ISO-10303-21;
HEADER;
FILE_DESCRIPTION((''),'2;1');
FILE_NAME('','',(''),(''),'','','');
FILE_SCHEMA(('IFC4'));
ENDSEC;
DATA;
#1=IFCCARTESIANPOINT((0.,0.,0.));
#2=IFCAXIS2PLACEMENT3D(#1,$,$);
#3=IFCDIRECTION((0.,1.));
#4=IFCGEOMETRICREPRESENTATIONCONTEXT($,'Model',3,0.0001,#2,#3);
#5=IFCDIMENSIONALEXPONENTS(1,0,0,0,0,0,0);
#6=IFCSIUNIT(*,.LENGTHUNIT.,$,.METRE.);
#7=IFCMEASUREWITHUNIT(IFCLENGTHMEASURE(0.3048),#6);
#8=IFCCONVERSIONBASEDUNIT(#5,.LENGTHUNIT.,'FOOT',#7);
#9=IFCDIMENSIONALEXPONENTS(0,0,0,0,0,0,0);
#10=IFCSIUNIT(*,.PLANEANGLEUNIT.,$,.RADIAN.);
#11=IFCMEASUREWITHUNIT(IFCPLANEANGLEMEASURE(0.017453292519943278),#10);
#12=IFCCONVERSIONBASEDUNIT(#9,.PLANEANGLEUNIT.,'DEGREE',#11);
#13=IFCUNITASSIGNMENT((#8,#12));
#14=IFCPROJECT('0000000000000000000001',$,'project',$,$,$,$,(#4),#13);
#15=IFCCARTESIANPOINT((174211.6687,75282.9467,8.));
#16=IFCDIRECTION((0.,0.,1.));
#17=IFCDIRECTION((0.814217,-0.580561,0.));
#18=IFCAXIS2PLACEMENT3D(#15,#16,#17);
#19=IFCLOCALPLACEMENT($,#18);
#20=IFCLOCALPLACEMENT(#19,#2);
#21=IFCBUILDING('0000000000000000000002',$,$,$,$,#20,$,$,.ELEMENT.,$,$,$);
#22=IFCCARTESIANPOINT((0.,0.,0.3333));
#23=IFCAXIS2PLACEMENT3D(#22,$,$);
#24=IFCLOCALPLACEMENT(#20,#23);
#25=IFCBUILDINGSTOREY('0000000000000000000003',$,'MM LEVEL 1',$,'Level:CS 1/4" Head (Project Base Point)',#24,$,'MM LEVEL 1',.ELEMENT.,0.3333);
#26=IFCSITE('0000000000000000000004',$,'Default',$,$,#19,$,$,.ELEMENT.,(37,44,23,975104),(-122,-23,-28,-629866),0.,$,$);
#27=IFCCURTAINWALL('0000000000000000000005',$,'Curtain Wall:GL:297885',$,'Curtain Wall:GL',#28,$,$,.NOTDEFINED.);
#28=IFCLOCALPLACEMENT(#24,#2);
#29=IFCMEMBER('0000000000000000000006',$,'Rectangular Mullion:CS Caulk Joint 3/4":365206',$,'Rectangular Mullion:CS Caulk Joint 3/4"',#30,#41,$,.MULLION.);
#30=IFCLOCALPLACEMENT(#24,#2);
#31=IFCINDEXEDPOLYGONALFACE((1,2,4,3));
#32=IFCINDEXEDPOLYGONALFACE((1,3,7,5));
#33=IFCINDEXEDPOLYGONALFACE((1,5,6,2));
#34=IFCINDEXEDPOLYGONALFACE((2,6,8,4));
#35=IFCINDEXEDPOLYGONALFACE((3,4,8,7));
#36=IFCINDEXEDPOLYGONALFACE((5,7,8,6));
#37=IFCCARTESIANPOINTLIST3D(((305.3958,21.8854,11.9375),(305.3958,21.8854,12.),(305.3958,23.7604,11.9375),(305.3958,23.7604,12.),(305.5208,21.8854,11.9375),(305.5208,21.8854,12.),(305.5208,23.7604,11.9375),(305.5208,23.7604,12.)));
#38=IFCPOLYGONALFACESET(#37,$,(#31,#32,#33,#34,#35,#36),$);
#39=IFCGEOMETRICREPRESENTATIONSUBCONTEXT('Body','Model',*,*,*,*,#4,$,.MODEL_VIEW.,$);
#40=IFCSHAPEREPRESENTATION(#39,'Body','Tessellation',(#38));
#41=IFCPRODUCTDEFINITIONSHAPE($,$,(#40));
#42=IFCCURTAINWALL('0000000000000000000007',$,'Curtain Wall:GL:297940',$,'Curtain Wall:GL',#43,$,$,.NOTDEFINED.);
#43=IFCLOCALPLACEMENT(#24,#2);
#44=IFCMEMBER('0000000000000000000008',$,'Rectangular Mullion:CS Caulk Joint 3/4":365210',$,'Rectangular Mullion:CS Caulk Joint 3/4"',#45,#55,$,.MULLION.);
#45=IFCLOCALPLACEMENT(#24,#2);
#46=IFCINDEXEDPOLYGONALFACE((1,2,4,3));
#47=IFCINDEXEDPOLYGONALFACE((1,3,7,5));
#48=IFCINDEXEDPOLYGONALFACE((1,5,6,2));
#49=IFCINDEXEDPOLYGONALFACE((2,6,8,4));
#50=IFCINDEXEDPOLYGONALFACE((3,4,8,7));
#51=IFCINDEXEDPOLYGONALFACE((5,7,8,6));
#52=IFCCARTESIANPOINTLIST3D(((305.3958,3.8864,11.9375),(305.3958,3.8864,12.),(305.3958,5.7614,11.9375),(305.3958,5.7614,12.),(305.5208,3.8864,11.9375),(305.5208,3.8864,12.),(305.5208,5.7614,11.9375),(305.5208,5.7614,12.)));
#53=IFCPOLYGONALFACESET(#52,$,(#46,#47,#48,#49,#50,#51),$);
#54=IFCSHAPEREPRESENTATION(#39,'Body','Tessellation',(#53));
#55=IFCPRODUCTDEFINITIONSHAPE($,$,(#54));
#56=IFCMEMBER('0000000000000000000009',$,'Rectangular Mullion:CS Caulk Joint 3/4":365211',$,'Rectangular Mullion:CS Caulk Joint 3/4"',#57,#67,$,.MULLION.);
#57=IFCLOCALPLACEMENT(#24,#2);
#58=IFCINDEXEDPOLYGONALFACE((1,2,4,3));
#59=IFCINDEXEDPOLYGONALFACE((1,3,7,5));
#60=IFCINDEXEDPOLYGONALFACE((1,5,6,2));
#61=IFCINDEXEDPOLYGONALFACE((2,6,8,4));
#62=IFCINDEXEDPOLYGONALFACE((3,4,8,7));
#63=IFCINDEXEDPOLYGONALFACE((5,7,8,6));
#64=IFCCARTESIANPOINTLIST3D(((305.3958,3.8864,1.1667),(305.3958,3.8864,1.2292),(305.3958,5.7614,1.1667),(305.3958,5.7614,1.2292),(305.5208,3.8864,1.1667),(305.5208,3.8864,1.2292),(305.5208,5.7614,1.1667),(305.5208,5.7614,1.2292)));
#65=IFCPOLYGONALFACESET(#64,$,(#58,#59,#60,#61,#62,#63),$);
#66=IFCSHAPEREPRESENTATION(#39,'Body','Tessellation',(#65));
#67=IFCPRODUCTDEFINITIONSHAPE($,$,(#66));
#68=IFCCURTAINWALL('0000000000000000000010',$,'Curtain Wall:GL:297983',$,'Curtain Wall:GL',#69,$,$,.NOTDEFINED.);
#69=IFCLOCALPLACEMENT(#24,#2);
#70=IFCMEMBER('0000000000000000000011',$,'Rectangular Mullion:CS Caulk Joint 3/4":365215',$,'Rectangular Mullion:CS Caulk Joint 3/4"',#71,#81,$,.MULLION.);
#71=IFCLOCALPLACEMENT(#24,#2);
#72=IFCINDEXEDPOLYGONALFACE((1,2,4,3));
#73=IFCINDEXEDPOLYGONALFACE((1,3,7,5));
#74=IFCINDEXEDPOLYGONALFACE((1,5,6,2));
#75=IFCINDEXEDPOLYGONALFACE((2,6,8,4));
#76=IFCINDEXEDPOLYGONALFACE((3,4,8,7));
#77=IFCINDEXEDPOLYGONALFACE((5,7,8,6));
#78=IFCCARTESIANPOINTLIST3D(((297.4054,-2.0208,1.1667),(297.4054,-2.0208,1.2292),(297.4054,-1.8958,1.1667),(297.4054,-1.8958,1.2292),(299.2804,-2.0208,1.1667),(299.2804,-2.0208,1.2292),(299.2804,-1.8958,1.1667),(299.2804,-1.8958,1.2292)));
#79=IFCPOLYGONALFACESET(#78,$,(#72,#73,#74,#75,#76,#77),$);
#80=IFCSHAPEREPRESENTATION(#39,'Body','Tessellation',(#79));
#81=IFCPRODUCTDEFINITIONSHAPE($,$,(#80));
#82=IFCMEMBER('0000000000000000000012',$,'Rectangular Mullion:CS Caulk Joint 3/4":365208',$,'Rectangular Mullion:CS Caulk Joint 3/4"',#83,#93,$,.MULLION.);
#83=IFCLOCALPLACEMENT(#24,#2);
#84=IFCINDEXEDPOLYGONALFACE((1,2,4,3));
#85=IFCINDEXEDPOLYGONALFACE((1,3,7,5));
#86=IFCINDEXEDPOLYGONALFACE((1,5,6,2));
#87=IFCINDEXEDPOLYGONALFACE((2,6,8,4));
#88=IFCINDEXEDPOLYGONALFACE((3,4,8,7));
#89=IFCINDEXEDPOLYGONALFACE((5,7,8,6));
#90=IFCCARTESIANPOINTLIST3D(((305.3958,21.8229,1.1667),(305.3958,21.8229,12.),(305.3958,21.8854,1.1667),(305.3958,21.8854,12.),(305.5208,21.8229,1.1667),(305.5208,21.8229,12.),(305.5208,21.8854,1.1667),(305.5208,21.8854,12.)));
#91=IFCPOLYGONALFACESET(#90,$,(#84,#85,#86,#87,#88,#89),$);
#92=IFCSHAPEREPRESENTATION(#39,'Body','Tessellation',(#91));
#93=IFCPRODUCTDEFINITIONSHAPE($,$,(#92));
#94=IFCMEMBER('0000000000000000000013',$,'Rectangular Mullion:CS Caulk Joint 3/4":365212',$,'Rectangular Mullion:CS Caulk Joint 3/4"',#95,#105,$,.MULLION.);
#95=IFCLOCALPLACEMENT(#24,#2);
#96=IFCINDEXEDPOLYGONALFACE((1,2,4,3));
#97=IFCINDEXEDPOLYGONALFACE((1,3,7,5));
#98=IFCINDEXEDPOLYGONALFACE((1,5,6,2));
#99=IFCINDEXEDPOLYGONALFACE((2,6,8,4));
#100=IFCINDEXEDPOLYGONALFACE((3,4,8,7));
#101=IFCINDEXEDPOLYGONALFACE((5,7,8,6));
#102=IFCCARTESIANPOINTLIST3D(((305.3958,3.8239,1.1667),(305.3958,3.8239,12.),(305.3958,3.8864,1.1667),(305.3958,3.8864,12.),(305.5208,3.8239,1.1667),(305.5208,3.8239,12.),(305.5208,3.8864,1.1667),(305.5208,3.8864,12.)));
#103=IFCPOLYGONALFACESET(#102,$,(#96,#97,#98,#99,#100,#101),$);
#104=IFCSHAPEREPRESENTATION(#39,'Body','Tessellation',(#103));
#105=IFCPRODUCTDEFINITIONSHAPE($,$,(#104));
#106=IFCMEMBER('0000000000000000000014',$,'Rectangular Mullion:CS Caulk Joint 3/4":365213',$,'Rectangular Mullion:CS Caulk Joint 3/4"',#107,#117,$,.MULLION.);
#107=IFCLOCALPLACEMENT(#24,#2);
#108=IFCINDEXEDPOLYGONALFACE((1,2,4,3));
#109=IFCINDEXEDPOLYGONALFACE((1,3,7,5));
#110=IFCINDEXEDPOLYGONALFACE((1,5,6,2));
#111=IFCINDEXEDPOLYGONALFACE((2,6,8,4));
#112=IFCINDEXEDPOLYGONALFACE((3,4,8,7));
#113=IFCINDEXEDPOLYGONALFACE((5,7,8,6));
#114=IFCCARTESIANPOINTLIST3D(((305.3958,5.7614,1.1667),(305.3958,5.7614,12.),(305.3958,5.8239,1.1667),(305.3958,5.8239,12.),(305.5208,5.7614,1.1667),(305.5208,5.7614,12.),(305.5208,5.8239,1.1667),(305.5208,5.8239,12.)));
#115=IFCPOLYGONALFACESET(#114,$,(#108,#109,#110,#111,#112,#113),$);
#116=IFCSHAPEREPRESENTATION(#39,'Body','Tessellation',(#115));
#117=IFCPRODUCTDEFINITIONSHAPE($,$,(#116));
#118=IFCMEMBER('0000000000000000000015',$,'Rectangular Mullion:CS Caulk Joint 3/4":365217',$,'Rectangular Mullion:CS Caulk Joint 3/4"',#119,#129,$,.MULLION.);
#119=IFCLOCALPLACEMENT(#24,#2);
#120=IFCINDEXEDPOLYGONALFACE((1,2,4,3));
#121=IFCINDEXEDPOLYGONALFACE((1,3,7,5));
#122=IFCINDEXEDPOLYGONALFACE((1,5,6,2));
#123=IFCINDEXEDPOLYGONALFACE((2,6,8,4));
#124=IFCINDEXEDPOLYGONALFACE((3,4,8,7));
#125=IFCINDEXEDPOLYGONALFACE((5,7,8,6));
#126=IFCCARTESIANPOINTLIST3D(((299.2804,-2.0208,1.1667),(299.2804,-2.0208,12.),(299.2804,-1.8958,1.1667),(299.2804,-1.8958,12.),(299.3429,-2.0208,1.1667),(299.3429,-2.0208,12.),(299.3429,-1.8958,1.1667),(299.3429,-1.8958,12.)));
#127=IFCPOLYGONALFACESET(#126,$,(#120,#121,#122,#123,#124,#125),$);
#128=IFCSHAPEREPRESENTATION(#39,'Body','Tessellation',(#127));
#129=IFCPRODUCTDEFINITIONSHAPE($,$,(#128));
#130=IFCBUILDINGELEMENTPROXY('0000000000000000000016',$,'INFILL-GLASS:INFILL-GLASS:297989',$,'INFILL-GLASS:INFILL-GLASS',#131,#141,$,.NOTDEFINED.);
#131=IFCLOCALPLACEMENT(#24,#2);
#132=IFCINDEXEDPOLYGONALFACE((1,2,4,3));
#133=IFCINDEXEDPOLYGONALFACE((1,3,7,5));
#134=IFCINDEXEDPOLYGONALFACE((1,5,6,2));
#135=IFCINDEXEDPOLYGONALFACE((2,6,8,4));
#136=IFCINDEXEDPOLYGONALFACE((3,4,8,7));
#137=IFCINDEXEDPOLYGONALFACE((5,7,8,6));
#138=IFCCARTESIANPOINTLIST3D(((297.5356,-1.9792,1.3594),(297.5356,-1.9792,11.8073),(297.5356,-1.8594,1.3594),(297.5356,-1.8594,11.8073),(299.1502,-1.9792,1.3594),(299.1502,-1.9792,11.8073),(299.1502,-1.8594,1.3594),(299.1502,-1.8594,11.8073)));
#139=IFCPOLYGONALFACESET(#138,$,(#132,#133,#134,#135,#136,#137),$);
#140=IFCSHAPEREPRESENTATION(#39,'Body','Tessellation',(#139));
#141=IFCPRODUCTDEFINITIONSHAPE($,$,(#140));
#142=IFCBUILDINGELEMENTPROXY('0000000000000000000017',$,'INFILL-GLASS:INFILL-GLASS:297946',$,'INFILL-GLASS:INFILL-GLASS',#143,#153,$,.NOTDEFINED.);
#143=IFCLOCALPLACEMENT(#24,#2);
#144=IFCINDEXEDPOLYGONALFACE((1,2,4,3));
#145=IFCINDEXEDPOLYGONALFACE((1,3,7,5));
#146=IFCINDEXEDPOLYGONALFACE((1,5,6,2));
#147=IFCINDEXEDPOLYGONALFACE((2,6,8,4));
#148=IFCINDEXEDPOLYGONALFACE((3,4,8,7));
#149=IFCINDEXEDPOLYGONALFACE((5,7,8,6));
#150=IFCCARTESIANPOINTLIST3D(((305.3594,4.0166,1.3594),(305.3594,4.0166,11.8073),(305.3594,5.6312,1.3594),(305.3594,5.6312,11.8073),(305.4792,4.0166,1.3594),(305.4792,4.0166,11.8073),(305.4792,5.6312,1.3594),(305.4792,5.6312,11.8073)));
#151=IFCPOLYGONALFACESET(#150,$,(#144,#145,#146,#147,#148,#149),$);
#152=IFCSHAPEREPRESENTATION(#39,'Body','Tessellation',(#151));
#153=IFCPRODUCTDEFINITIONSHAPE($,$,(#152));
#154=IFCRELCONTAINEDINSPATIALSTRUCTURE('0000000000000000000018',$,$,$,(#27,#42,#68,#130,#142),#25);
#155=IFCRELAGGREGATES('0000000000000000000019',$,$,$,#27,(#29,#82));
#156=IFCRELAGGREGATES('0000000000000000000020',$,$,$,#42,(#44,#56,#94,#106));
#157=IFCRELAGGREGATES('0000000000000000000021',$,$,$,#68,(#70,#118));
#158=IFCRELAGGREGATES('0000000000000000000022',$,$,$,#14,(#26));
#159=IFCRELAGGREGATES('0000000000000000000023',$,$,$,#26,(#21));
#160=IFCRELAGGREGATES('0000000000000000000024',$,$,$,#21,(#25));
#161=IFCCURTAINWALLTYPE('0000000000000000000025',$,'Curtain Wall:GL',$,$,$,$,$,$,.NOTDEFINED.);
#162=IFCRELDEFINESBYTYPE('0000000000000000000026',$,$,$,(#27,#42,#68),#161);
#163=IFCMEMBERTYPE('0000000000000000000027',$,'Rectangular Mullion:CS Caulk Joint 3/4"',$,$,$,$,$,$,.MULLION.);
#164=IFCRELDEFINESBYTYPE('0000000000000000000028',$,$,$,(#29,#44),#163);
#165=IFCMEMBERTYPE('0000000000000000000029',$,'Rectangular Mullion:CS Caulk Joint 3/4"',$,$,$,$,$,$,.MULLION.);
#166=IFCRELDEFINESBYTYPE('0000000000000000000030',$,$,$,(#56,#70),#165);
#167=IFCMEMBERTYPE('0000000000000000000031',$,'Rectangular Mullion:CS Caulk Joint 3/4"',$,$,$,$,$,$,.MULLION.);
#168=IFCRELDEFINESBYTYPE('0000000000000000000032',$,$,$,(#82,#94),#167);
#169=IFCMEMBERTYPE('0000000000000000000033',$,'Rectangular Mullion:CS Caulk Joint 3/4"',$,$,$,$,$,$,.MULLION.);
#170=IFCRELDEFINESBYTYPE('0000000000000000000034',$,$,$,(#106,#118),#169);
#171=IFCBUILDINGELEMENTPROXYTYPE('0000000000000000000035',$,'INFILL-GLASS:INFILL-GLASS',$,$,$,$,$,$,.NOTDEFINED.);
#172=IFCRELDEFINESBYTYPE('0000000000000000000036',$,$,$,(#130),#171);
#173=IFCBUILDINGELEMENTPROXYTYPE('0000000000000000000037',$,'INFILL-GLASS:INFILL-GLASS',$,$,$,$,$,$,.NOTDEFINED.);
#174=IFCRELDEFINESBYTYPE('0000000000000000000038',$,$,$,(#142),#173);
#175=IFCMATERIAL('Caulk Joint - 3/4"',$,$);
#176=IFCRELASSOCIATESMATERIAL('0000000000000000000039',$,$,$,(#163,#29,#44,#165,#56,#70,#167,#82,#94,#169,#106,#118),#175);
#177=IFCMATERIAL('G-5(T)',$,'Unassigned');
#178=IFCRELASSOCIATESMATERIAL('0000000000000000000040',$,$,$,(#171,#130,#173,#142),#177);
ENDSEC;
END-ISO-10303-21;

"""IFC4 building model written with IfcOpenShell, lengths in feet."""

from ifc_helpers import new_model, entity, si_unit, converted_unit, direction, frame, origin, place, context, subcontext, project, spatial, indexed_curve, outline, extrude, source, transform, mapped, material, type_object, type_shapes, element, aggregate, save


model = new_model("IFC4")

# Units and contexts
model_context = context("Model", 3, precision=0.0001, world=origin(), true_north=direction((0.0, 1.0)))
body_context = subcontext(model_context, "Body", "Model", "MODEL_VIEW")
ifc_project = project(units=[converted_unit("LENGTHUNIT", "FOOT", entity("IfcLengthMeasure", 0.3048), si_unit("LENGTHUNIT", "METRE"), dimensions=[1, 0, 0, 0, 0, 0, 0]), converted_unit("PLANEANGLEUNIT", "DEGREE", entity("IfcPlaneAngleMeasure", 0.017453292519943278), si_unit("PLANEANGLEUNIT", "RADIAN"), dimensions=[0, 0, 0, 0, 0, 0, 0])], contexts=[model_context])

# Site, building, storey
site_placement = place(None, frame((174211.6687, 75282.9467, 8.0), z_axis=(0.0, 0.0, 1.0), x_axis=(0.814217, -0.580561, 0.0)))
site = spatial("IfcSite", under=ifc_project, at=site_placement, Name="Default", CompositionType="ELEMENT", RefLatitude=(37, 44, 23, 975104), RefLongitude=(-122, -23, -28, -629866), RefElevation=0.0)
building_placement = place(site_placement, origin())
building = spatial("IfcBuilding", under=site, at=building_placement, CompositionType="ELEMENT")
storey_placement = place(building_placement, frame((0.0, 0.0, 0.3333)))
storey = spatial("IfcBuildingStorey", under=building, at=storey_placement, Name="MM LEVEL 1", ObjectType="Level:CS 1/4\" Head (Project Base Point)", LongName="MM LEVEL 1", CompositionType="ELEMENT", Elevation=0.3333)

# Curtain wall, member
curtain_wall_type_1 = type_object("IfcCurtainWallType", Name="Curtain Wall:GL", PredefinedType="NOTDEFINED")
curtain_wall_1_placement = place(storey_placement, frame((0.0, 0.0, -0.3333)))
curtain_wall_1 = element("IfcCurtainWall", 1, at=curtain_wall_1_placement, inside=storey, type_object=curtain_wall_type_1, Name="Curtain Wall:GL:297885", ObjectType="Curtain Wall:GL", PredefinedType="NOTDEFINED")
ifc_material_1 = material(Name="Caulk Joint - 3/4\"")
member_type_1 = type_object("IfcMemberType", Name="Rectangular Mullion:CS Caulk Joint 3/4\"", PredefinedType="MULLION", material=ifc_material_1)
shared_shape_1 = source(origin(), body_context, "Body", "SweptSolid", [
    extrude(outline(indexed_curve([(-0.0625, -0.0312), (0.0625, -0.0312), (0.0625, 0.0312), (-0.0625, 0.0312), (-0.0625, -0.0312)], self_intersect=False)), frame((-0.0312, 0.0625, -1.875), z_axis=(0.0, 0.0, 1.0), x_axis=(0.0, -1.0, 0.0)), (0.0, 0.0, 1.0), 1.875),
])
type_shapes(member_type_1, [shared_shape_1])
member_1_placement = place(curtain_wall_1_placement, frame((305.5208, 21.8854, 12.3333), z_axis=(0.0, -1.0, 0.0), x_axis=(0.0, 0.0, 1.0)))
member_1 = element("IfcMember", 2, at=member_1_placement, type_object=member_type_1, material=ifc_material_1, Name="Rectangular Mullion:CS Caulk Joint 3/4\":365206", ObjectType="Rectangular Mullion:CS Caulk Joint 3/4\"", PredefinedType="MULLION", context=body_context, shape_type="MappedRepresentation", body=[
    mapped(shared_shape_1, transform((0.0, 0.0, 0.0), scale=1.0)),
])

# Curtain wall, members
curtain_wall_2_placement = place(storey_placement, frame((0.0, 0.0, -0.3333)))
curtain_wall_2 = element("IfcCurtainWall", 3, at=curtain_wall_2_placement, inside=storey, type_object=curtain_wall_type_1, Name="Curtain Wall:GL:297940", ObjectType="Curtain Wall:GL", PredefinedType="NOTDEFINED")
member_2_placement = place(curtain_wall_2_placement, frame((305.5208, 3.8864, 12.3333), z_axis=(0.0, -1.0, 0.0), x_axis=(0.0, 0.0, 1.0)))
member_2 = element("IfcMember", 4, at=member_2_placement, type_object=member_type_1, material=ifc_material_1, Name="Rectangular Mullion:CS Caulk Joint 3/4\":365210", ObjectType="Rectangular Mullion:CS Caulk Joint 3/4\"", PredefinedType="MULLION", context=body_context, shape_type="MappedRepresentation", body=[
    mapped(shared_shape_1, transform((0.0, 0.0, 0.0), scale=1.0)),
])
member_type_2 = type_object("IfcMemberType", Name="Rectangular Mullion:CS Caulk Joint 3/4\"", PredefinedType="MULLION", material=ifc_material_1)
shared_shape_2 = source(origin(), body_context, "Body", "SweptSolid", [
    extrude(outline(indexed_curve([(-0.0312, -0.0625), (0.0312, -0.0625), (0.0312, 0.0625), (-0.0312, 0.0625), (-0.0312, -0.0625)], self_intersect=False)), frame((-0.0312, 0.0625, -1.875), z_axis=(0.0, 0.0, 1.0), x_axis=(-1.0, 0.0, 0.0)), (0.0, 0.0, 1.0), 1.875),
])
type_shapes(member_type_2, [shared_shape_2])
member_3_placement = place(curtain_wall_2_placement, frame((305.5208, 5.7614, 1.5), z_axis=(0.0, 1.0, 0.0), x_axis=(0.0, 0.0, -1.0)))
member_3 = element("IfcMember", 5, at=member_3_placement, type_object=member_type_2, material=ifc_material_1, Name="Rectangular Mullion:CS Caulk Joint 3/4\":365211", ObjectType="Rectangular Mullion:CS Caulk Joint 3/4\"", PredefinedType="MULLION", context=body_context, shape_type="MappedRepresentation", body=[
    mapped(shared_shape_2, transform((0.0, 0.0, 0.0), scale=1.0)),
])

# Curtain wall, member
curtain_wall_3_placement = place(storey_placement, frame((0.0, 0.0, -0.3333)))
curtain_wall_3 = element("IfcCurtainWall", 6, at=curtain_wall_3_placement, inside=storey, type_object=curtain_wall_type_1, Name="Curtain Wall:GL:297983", ObjectType="Curtain Wall:GL", PredefinedType="NOTDEFINED")
member_4_placement = place(curtain_wall_3_placement, frame((299.2804, -2.0208, 1.5), z_axis=(1.0, 0.0, 0.0), x_axis=(0.0, 0.0, -1.0)))
member_4 = element("IfcMember", 7, at=member_4_placement, type_object=member_type_2, material=ifc_material_1, Name="Rectangular Mullion:CS Caulk Joint 3/4\":365215", ObjectType="Rectangular Mullion:CS Caulk Joint 3/4\"", PredefinedType="MULLION", context=body_context, shape_type="MappedRepresentation", body=[
    mapped(shared_shape_2, transform((0.0, 0.0, 0.0), scale=1.0)),
])

# Members
member_type_3 = type_object("IfcMemberType", Name="Rectangular Mullion:CS Caulk Joint 3/4\"", PredefinedType="MULLION", material=ifc_material_1)
shared_shape_3 = source(origin(), body_context, "Body", "SweptSolid", [
    extrude(outline(indexed_curve([(-0.0625, -0.0312), (0.0625, -0.0312), (0.0625, 0.0312), (-0.0625, 0.0312), (-0.0625, -0.0312)], self_intersect=False)), frame((-0.0312, 0.0625, -10.8333), z_axis=(0.0, 0.0, 1.0), x_axis=(0.0, -1.0, 0.0)), (0.0, 0.0, 1.0), 10.8333),
])
type_shapes(member_type_3, [shared_shape_3])
member_5_placement = place(curtain_wall_1_placement, frame((305.5208, 21.8229, 1.5), z_axis=(0.0, 0.0, -1.0), x_axis=(0.0, -1.0, 0.0)))
member_5 = element("IfcMember", 8, at=member_5_placement, type_object=member_type_3, material=ifc_material_1, Name="Rectangular Mullion:CS Caulk Joint 3/4\":365208", ObjectType="Rectangular Mullion:CS Caulk Joint 3/4\"", PredefinedType="MULLION", context=body_context, shape_type="MappedRepresentation", body=[
    mapped(shared_shape_3, transform((0.0, 0.0, 0.0), scale=1.0)),
])
aggregate(curtain_wall_1, [member_1, member_5])
member_6_placement = place(curtain_wall_2_placement, frame((305.5208, 3.8239, 1.5), z_axis=(0.0, 0.0, -1.0), x_axis=(0.0, -1.0, 0.0)))
member_6 = element("IfcMember", 9, at=member_6_placement, type_object=member_type_3, material=ifc_material_1, Name="Rectangular Mullion:CS Caulk Joint 3/4\":365212", ObjectType="Rectangular Mullion:CS Caulk Joint 3/4\"", PredefinedType="MULLION", context=body_context, shape_type="MappedRepresentation", body=[
    mapped(shared_shape_3, transform((0.0, 0.0, 0.0), scale=1.0)),
])
member_type_4 = type_object("IfcMemberType", Name="Rectangular Mullion:CS Caulk Joint 3/4\"", PredefinedType="MULLION", material=ifc_material_1)
shared_shape_4 = source(origin(), body_context, "Body", "SweptSolid", [
    extrude(outline(indexed_curve([(-0.0312, -0.0625), (0.0312, -0.0625), (0.0312, 0.0625), (-0.0312, 0.0625), (-0.0312, -0.0625)], self_intersect=False)), frame((-0.0312, 0.0625, -10.8333), z_axis=(0.0, 0.0, 1.0), x_axis=(-1.0, 0.0, 0.0)), (0.0, 0.0, 1.0), 10.8333),
])
type_shapes(member_type_4, [shared_shape_4])
member_7_placement = place(curtain_wall_2_placement, frame((305.5208, 5.8239, 12.3333), z_axis=(0.0, 0.0, 1.0), x_axis=(0.0, 1.0, 0.0)))
member_7 = element("IfcMember", 10, at=member_7_placement, type_object=member_type_4, material=ifc_material_1, Name="Rectangular Mullion:CS Caulk Joint 3/4\":365213", ObjectType="Rectangular Mullion:CS Caulk Joint 3/4\"", PredefinedType="MULLION", context=body_context, shape_type="MappedRepresentation", body=[
    mapped(shared_shape_4, transform((0.0, 0.0, 0.0), scale=1.0)),
])
aggregate(curtain_wall_2, [member_2, member_3, member_6, member_7])
member_8_placement = place(curtain_wall_3_placement, frame((299.3429, -2.0208, 12.3333)))
member_8 = element("IfcMember", 11, at=member_8_placement, type_object=member_type_4, material=ifc_material_1, Name="Rectangular Mullion:CS Caulk Joint 3/4\":365217", ObjectType="Rectangular Mullion:CS Caulk Joint 3/4\"", PredefinedType="MULLION", context=body_context, shape_type="MappedRepresentation", body=[
    mapped(shared_shape_4, transform((0.0, 0.0, 0.0), scale=1.0)),
])
aggregate(curtain_wall_3, [member_4, member_8])

# Building element proxies
ifc_material_2 = material(Name="G-5(T)", Category="Unassigned")
building_element_proxy_type_1 = type_object("IfcBuildingElementProxyType", Name="INFILL-GLASS:INFILL-GLASS", PredefinedType="NOTDEFINED", material=ifc_material_2)
shared_shape_5 = source(origin(), body_context, "Body", "SweptSolid", [
    extrude(outline(indexed_curve([(-0.0599, -0.8073), (0.0599, -0.8073), (0.0599, 0.8073), (-0.0599, 0.8073), (-0.0599, -0.8073)], self_intersect=False)), frame((0.0, 0.1016, 0.1302), z_axis=(0.0, 0.0, 1.0), x_axis=(0.0, 1.0, 0.0)), (0.0, 0.0, 1.0), 10.4479),
])
type_shapes(building_element_proxy_type_1, [shared_shape_5])
proxy_1_placement = place(storey_placement, frame((298.3429, -2.0208, 1.2292)))
element("IfcBuildingElementProxy", 12, at=proxy_1_placement, inside=storey, type_object=building_element_proxy_type_1, material=ifc_material_2, Name="INFILL-GLASS:INFILL-GLASS:297989", ObjectType="INFILL-GLASS:INFILL-GLASS", PredefinedType="NOTDEFINED", context=body_context, shape_type="MappedRepresentation", body=[
    mapped(shared_shape_5, transform((0.0, 0.0, 0.0), scale=1.0)),
])
building_element_proxy_type_2 = type_object("IfcBuildingElementProxyType", Name="INFILL-GLASS:INFILL-GLASS", PredefinedType="NOTDEFINED", material=ifc_material_2)
shared_shape_6 = source(origin(), body_context, "Body", "SweptSolid", [
    extrude(outline(indexed_curve([(-0.0599, -0.8073), (0.0599, -0.8073), (0.0599, 0.8073), (-0.0599, 0.8073), (-0.0599, -0.8073)], self_intersect=False)), frame((0.0, 0.1016, 0.1302), z_axis=(0.0, 0.0, 1.0), x_axis=(0.0, 1.0, 0.0)), (0.0, 0.0, 1.0), 10.4479),
])
type_shapes(building_element_proxy_type_2, [shared_shape_6])
proxy_2_placement = place(storey_placement, frame((305.5208, 4.8239, 1.2292), z_axis=(0.0, 0.0, 1.0), x_axis=(0.0, 1.0, 0.0)))
element("IfcBuildingElementProxy", 13, at=proxy_2_placement, inside=storey, type_object=building_element_proxy_type_2, material=ifc_material_2, Name="INFILL-GLASS:INFILL-GLASS:297946", ObjectType="INFILL-GLASS:INFILL-GLASS", PredefinedType="NOTDEFINED", context=body_context, shape_type="MappedRepresentation", body=[
    mapped(shared_shape_6, transform((0.0, 0.0, 0.0), scale=1.0)),
])

save(model, "model.ifc")
